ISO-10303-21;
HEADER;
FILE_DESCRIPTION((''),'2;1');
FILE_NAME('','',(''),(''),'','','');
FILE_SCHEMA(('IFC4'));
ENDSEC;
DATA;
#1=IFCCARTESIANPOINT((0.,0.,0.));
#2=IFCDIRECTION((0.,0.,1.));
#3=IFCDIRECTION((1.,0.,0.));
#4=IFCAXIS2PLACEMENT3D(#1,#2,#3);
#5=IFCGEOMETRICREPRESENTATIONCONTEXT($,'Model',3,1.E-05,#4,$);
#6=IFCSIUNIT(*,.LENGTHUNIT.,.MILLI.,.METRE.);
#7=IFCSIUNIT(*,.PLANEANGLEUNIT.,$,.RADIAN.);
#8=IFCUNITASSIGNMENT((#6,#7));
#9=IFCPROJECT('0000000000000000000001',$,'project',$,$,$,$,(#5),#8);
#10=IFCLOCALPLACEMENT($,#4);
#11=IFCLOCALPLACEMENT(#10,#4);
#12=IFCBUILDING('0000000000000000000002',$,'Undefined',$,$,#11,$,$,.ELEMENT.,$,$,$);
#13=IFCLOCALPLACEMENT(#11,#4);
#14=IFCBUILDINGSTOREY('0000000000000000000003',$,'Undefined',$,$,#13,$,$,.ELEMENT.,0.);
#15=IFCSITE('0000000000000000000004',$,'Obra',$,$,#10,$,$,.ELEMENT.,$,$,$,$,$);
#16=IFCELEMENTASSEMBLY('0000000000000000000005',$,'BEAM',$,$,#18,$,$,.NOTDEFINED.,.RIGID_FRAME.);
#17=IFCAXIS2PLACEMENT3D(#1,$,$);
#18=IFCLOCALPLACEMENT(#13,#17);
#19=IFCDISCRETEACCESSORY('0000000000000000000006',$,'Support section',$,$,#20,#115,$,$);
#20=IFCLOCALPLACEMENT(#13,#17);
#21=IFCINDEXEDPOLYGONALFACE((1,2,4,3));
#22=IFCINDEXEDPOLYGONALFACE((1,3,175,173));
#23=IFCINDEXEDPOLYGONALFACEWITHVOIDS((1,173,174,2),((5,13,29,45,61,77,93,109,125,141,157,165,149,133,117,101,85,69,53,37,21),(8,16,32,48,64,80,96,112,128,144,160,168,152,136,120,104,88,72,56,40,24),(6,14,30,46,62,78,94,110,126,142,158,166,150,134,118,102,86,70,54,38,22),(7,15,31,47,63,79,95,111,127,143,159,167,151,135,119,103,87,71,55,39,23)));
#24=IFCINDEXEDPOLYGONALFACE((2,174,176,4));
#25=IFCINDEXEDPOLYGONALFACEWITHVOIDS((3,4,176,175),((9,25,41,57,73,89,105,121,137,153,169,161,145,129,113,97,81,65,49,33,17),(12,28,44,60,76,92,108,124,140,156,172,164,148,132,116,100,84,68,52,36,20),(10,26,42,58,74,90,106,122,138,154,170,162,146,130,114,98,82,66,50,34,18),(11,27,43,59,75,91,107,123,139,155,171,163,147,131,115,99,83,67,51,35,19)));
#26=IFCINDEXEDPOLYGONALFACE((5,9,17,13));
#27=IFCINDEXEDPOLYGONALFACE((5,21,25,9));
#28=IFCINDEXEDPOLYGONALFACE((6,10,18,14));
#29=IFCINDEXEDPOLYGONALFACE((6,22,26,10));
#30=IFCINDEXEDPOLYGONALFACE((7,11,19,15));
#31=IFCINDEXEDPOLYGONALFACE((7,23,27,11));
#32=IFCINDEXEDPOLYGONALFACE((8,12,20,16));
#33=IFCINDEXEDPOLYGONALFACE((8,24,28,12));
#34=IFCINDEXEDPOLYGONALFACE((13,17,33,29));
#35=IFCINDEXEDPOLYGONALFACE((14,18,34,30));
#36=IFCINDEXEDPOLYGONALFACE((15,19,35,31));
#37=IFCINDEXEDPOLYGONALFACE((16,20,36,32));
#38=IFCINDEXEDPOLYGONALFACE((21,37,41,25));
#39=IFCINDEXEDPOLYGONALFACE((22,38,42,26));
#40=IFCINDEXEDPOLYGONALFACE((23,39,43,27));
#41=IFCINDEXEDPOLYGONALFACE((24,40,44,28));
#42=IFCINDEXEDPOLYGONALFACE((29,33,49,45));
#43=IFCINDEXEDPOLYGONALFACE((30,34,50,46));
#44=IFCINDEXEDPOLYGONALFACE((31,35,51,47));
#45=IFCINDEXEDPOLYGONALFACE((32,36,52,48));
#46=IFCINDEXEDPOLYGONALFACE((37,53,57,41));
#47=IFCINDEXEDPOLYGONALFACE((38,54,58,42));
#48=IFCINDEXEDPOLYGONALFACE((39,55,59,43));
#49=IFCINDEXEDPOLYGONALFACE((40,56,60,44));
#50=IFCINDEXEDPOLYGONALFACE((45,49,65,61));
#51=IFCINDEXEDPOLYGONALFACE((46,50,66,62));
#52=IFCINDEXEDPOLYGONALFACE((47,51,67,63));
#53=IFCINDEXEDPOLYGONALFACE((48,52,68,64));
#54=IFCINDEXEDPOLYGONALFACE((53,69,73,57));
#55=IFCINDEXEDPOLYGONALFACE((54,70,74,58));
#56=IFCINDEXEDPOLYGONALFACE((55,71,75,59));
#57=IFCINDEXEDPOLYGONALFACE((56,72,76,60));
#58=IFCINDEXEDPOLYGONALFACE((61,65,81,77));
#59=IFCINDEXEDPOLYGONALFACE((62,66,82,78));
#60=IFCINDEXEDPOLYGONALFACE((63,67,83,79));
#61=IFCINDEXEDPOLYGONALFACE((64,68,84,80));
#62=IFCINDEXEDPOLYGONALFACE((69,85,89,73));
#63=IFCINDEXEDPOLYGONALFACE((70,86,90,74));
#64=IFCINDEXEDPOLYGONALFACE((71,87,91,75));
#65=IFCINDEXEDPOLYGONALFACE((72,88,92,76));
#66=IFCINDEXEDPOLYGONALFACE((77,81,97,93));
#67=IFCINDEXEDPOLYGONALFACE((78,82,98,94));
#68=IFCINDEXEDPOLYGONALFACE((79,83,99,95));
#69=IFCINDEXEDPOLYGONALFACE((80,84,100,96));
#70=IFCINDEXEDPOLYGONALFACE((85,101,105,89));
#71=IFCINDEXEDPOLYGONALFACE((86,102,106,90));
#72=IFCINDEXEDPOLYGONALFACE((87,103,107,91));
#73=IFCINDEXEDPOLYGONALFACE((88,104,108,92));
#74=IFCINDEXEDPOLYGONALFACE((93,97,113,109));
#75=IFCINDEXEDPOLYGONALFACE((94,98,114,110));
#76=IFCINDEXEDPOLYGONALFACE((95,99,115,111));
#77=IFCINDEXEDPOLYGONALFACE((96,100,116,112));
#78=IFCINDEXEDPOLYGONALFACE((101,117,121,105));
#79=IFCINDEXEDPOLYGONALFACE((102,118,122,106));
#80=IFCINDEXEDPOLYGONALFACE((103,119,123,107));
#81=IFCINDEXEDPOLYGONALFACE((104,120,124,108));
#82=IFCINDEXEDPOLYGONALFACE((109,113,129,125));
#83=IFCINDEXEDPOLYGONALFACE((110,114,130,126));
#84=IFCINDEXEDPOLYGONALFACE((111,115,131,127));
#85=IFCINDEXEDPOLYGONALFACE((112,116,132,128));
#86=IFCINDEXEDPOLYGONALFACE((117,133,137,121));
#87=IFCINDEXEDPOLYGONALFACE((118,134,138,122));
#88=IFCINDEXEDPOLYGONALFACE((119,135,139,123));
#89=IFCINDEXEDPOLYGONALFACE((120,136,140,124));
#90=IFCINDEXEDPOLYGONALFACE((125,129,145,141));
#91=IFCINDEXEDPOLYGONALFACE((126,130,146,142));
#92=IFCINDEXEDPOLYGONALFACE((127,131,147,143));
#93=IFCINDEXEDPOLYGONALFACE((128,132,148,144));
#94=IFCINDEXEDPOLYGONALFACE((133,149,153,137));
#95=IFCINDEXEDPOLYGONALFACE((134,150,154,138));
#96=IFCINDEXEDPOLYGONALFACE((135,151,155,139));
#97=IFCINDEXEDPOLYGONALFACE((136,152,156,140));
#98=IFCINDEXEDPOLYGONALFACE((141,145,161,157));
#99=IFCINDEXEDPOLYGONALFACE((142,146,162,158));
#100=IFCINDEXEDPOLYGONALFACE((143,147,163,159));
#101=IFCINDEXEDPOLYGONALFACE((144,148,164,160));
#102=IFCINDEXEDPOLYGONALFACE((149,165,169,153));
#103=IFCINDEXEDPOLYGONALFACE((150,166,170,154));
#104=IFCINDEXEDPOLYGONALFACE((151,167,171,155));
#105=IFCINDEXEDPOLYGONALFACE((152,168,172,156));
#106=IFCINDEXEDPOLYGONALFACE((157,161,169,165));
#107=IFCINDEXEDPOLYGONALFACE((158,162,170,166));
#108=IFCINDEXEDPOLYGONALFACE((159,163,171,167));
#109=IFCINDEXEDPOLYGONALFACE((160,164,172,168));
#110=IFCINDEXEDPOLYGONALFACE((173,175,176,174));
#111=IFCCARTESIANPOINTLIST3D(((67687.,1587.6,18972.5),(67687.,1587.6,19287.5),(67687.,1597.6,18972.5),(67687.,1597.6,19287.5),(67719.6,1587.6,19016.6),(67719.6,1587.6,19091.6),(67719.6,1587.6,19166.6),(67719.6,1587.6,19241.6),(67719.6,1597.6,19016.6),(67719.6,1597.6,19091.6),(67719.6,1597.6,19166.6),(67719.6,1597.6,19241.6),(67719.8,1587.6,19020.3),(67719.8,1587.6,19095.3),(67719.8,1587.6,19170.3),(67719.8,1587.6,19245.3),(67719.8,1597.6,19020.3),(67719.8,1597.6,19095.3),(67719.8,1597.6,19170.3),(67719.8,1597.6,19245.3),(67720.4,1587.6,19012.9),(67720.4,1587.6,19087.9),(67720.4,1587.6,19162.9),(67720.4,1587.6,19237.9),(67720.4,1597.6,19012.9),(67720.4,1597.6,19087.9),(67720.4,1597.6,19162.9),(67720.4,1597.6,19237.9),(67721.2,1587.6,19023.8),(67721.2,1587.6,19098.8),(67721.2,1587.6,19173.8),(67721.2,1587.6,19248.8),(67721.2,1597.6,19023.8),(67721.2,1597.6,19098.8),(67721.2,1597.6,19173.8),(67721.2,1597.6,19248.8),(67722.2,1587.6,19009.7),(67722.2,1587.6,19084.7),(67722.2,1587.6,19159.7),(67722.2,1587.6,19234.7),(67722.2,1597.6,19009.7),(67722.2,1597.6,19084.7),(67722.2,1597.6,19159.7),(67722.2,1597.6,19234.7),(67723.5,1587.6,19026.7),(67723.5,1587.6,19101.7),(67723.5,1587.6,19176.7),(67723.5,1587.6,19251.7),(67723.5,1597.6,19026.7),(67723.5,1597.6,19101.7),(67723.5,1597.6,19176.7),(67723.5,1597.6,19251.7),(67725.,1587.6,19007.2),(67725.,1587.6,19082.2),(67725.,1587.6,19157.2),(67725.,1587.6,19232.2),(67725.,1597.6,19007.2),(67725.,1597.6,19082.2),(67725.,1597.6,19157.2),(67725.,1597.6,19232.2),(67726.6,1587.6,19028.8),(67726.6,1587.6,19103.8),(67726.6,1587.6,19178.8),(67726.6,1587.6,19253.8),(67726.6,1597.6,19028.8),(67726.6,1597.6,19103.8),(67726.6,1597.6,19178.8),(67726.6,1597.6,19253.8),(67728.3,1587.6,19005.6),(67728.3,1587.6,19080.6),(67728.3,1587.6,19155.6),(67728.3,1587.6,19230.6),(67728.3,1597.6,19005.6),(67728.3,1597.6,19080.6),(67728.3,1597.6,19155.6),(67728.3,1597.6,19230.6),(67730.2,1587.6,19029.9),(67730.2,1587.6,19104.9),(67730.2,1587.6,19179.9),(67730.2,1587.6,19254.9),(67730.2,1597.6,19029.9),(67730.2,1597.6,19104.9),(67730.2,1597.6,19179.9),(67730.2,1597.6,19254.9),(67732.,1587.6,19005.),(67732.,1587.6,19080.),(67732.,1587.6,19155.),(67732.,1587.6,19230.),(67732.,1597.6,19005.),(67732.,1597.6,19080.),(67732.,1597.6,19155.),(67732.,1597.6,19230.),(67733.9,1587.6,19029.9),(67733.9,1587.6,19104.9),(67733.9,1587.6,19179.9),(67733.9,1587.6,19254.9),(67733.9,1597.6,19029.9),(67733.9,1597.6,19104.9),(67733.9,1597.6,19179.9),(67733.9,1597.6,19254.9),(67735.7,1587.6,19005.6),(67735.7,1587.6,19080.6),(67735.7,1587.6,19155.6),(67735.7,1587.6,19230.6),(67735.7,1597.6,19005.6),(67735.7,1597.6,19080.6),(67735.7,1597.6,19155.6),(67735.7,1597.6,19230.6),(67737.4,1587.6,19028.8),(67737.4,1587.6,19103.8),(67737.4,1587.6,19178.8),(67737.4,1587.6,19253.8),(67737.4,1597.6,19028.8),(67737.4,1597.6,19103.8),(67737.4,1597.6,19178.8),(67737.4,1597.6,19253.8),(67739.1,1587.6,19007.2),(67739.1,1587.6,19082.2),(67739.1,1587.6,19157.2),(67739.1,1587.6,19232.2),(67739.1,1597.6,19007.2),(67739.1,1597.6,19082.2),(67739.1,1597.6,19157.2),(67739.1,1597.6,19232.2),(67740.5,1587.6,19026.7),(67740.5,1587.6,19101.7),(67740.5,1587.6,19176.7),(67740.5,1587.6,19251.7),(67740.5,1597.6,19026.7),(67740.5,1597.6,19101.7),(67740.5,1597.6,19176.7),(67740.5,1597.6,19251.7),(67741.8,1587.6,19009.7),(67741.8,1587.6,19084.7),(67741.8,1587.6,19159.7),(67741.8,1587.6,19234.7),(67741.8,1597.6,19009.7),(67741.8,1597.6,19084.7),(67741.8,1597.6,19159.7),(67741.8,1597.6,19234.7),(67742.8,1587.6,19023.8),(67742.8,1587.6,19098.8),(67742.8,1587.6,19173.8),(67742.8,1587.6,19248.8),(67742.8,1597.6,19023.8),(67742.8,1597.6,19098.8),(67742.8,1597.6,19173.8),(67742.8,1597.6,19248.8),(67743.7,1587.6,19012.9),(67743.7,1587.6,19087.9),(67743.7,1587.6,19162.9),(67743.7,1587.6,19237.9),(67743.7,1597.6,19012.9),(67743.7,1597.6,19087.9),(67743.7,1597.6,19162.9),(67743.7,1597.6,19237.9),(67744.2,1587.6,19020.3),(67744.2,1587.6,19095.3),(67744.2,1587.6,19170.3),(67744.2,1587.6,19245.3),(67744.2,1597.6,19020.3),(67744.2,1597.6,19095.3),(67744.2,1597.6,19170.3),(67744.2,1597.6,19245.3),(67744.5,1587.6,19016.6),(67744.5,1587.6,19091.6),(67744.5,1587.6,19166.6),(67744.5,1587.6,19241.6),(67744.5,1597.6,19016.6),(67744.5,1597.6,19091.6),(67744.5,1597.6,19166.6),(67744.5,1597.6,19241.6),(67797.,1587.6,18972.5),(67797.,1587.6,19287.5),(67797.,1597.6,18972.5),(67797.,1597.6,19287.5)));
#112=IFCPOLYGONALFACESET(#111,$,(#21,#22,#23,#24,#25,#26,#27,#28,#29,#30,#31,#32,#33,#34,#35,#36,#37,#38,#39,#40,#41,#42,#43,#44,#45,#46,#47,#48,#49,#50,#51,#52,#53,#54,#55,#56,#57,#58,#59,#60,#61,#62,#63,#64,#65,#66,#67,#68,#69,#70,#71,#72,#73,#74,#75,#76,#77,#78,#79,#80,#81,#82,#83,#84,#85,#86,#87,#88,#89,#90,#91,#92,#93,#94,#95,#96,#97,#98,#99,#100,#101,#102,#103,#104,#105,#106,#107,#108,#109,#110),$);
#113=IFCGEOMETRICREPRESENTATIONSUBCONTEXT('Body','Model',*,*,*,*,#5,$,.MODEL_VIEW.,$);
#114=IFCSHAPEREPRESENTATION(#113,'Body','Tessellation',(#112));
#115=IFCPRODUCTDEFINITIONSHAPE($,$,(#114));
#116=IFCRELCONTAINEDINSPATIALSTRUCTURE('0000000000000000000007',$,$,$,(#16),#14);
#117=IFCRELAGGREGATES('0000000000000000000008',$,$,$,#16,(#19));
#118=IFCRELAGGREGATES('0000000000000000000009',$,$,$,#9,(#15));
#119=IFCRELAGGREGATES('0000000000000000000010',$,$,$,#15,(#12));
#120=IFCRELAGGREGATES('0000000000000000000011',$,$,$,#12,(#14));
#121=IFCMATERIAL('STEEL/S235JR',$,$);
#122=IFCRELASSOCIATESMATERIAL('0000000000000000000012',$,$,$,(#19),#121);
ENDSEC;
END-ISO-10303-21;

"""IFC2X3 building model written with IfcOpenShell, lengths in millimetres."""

from ifc_helpers import new_model, si_unit, frame, origin_with_axes, origin_2d_with_axis, place, context, subcontext, project, spatial, rectangle, circle, extrude, source, transform, mapped, material, element, aggregate, save


model = new_model("IFC2X3")

# Units and contexts
model_context = context("Model", 3, precision=1e-05, world=origin_with_axes())
body_context = subcontext(model_context, "Body", "Model", "MODEL_VIEW")
ifc_project = project(units=[si_unit("LENGTHUNIT", "METRE", prefix="MILLI"), si_unit("PLANEANGLEUNIT", "RADIAN")], contexts=[model_context])

# Site, building, storey
site_placement = place(None, origin_with_axes())
site = spatial("IfcSite", under=ifc_project, at=site_placement, Name="Obra", CompositionType="ELEMENT")
building_placement = place(site_placement, origin_with_axes())
building = spatial("IfcBuilding", under=site, at=building_placement, Name="Undefined", CompositionType="ELEMENT")
storey_placement = place(building_placement, origin_with_axes())
storey = spatial("IfcBuildingStorey", under=building, at=storey_placement, Name="Undefined", CompositionType="ELEMENT", Elevation=0.0)

# Element assembly
assembly_1_placement = place(storey_placement, origin_with_axes())
assembly_1 = element("IfcElementAssembly", 1, at=assembly_1_placement, inside=storey, Name="BEAM", AssemblyPlace="NOTDEFINED", PredefinedType="RIGID_FRAME")

# Shared definitions
ifc_material_1 = material(Name="STEEL/S235JR")

# Discrete accessory, opening
discrete_accessory_1_placement = place(assembly_1_placement, frame((67742.0, 1592.6, 18972.5), z_axis=(0.0, 0.0, 1.0), x_axis=(1.0, 0.0, 0.0)))
discrete_accessory_1 = element("IfcDiscreteAccessory", 2, at=discrete_accessory_1_placement, material=ifc_material_1, Name="Support section", context=body_context, shape_type="SweptSolid", body=[
    extrude(rectangle(XDim=10.0, YDim=110.0, at=origin_2d_with_axis()), frame((0.0, 0.0, 315.0), z_axis=(0.0, 0.0, -1.0), x_axis=(0.0, 1.0, 0.0)), (0.0, 0.0, 1.0), 315.0),
])
shared_shape_1 = source(origin_with_axes(), body_context, "Body", "SweptSolid", [
    extrude(circle(Radius=12.5, at=origin_2d_with_axis()), frame((0.0, 5.7, 0.0), z_axis=(0.0, 1.0, 0.0), x_axis=(1.0, 0.0, 0.0)), (0.0, 0.0, 1.0), 10.2),
])
opening_1_placement = place(assembly_1_placement, frame((67777.0, 1603.4, 19350.0), z_axis=(-1.0, 0.0, 0.0), x_axis=(0.0, 0.0, -1.0)))
element("IfcOpeningElement", 3, at=opening_1_placement, cuts=discrete_accessory_1, ObjectType="Opening", context=body_context, shape_type="MappedRepresentation", body=[
    mapped(shared_shape_1, transform((107.5, 0.0, 45.0))),
    mapped(shared_shape_1, transform((182.5, 0.0, 45.0))),
    mapped(shared_shape_1, transform((257.5, 0.0, 45.0))),
    mapped(shared_shape_1, transform((332.5, 0.0, 45.0))),
])
aggregate(assembly_1, [discrete_accessory_1])

save(model, "model.ifc")
